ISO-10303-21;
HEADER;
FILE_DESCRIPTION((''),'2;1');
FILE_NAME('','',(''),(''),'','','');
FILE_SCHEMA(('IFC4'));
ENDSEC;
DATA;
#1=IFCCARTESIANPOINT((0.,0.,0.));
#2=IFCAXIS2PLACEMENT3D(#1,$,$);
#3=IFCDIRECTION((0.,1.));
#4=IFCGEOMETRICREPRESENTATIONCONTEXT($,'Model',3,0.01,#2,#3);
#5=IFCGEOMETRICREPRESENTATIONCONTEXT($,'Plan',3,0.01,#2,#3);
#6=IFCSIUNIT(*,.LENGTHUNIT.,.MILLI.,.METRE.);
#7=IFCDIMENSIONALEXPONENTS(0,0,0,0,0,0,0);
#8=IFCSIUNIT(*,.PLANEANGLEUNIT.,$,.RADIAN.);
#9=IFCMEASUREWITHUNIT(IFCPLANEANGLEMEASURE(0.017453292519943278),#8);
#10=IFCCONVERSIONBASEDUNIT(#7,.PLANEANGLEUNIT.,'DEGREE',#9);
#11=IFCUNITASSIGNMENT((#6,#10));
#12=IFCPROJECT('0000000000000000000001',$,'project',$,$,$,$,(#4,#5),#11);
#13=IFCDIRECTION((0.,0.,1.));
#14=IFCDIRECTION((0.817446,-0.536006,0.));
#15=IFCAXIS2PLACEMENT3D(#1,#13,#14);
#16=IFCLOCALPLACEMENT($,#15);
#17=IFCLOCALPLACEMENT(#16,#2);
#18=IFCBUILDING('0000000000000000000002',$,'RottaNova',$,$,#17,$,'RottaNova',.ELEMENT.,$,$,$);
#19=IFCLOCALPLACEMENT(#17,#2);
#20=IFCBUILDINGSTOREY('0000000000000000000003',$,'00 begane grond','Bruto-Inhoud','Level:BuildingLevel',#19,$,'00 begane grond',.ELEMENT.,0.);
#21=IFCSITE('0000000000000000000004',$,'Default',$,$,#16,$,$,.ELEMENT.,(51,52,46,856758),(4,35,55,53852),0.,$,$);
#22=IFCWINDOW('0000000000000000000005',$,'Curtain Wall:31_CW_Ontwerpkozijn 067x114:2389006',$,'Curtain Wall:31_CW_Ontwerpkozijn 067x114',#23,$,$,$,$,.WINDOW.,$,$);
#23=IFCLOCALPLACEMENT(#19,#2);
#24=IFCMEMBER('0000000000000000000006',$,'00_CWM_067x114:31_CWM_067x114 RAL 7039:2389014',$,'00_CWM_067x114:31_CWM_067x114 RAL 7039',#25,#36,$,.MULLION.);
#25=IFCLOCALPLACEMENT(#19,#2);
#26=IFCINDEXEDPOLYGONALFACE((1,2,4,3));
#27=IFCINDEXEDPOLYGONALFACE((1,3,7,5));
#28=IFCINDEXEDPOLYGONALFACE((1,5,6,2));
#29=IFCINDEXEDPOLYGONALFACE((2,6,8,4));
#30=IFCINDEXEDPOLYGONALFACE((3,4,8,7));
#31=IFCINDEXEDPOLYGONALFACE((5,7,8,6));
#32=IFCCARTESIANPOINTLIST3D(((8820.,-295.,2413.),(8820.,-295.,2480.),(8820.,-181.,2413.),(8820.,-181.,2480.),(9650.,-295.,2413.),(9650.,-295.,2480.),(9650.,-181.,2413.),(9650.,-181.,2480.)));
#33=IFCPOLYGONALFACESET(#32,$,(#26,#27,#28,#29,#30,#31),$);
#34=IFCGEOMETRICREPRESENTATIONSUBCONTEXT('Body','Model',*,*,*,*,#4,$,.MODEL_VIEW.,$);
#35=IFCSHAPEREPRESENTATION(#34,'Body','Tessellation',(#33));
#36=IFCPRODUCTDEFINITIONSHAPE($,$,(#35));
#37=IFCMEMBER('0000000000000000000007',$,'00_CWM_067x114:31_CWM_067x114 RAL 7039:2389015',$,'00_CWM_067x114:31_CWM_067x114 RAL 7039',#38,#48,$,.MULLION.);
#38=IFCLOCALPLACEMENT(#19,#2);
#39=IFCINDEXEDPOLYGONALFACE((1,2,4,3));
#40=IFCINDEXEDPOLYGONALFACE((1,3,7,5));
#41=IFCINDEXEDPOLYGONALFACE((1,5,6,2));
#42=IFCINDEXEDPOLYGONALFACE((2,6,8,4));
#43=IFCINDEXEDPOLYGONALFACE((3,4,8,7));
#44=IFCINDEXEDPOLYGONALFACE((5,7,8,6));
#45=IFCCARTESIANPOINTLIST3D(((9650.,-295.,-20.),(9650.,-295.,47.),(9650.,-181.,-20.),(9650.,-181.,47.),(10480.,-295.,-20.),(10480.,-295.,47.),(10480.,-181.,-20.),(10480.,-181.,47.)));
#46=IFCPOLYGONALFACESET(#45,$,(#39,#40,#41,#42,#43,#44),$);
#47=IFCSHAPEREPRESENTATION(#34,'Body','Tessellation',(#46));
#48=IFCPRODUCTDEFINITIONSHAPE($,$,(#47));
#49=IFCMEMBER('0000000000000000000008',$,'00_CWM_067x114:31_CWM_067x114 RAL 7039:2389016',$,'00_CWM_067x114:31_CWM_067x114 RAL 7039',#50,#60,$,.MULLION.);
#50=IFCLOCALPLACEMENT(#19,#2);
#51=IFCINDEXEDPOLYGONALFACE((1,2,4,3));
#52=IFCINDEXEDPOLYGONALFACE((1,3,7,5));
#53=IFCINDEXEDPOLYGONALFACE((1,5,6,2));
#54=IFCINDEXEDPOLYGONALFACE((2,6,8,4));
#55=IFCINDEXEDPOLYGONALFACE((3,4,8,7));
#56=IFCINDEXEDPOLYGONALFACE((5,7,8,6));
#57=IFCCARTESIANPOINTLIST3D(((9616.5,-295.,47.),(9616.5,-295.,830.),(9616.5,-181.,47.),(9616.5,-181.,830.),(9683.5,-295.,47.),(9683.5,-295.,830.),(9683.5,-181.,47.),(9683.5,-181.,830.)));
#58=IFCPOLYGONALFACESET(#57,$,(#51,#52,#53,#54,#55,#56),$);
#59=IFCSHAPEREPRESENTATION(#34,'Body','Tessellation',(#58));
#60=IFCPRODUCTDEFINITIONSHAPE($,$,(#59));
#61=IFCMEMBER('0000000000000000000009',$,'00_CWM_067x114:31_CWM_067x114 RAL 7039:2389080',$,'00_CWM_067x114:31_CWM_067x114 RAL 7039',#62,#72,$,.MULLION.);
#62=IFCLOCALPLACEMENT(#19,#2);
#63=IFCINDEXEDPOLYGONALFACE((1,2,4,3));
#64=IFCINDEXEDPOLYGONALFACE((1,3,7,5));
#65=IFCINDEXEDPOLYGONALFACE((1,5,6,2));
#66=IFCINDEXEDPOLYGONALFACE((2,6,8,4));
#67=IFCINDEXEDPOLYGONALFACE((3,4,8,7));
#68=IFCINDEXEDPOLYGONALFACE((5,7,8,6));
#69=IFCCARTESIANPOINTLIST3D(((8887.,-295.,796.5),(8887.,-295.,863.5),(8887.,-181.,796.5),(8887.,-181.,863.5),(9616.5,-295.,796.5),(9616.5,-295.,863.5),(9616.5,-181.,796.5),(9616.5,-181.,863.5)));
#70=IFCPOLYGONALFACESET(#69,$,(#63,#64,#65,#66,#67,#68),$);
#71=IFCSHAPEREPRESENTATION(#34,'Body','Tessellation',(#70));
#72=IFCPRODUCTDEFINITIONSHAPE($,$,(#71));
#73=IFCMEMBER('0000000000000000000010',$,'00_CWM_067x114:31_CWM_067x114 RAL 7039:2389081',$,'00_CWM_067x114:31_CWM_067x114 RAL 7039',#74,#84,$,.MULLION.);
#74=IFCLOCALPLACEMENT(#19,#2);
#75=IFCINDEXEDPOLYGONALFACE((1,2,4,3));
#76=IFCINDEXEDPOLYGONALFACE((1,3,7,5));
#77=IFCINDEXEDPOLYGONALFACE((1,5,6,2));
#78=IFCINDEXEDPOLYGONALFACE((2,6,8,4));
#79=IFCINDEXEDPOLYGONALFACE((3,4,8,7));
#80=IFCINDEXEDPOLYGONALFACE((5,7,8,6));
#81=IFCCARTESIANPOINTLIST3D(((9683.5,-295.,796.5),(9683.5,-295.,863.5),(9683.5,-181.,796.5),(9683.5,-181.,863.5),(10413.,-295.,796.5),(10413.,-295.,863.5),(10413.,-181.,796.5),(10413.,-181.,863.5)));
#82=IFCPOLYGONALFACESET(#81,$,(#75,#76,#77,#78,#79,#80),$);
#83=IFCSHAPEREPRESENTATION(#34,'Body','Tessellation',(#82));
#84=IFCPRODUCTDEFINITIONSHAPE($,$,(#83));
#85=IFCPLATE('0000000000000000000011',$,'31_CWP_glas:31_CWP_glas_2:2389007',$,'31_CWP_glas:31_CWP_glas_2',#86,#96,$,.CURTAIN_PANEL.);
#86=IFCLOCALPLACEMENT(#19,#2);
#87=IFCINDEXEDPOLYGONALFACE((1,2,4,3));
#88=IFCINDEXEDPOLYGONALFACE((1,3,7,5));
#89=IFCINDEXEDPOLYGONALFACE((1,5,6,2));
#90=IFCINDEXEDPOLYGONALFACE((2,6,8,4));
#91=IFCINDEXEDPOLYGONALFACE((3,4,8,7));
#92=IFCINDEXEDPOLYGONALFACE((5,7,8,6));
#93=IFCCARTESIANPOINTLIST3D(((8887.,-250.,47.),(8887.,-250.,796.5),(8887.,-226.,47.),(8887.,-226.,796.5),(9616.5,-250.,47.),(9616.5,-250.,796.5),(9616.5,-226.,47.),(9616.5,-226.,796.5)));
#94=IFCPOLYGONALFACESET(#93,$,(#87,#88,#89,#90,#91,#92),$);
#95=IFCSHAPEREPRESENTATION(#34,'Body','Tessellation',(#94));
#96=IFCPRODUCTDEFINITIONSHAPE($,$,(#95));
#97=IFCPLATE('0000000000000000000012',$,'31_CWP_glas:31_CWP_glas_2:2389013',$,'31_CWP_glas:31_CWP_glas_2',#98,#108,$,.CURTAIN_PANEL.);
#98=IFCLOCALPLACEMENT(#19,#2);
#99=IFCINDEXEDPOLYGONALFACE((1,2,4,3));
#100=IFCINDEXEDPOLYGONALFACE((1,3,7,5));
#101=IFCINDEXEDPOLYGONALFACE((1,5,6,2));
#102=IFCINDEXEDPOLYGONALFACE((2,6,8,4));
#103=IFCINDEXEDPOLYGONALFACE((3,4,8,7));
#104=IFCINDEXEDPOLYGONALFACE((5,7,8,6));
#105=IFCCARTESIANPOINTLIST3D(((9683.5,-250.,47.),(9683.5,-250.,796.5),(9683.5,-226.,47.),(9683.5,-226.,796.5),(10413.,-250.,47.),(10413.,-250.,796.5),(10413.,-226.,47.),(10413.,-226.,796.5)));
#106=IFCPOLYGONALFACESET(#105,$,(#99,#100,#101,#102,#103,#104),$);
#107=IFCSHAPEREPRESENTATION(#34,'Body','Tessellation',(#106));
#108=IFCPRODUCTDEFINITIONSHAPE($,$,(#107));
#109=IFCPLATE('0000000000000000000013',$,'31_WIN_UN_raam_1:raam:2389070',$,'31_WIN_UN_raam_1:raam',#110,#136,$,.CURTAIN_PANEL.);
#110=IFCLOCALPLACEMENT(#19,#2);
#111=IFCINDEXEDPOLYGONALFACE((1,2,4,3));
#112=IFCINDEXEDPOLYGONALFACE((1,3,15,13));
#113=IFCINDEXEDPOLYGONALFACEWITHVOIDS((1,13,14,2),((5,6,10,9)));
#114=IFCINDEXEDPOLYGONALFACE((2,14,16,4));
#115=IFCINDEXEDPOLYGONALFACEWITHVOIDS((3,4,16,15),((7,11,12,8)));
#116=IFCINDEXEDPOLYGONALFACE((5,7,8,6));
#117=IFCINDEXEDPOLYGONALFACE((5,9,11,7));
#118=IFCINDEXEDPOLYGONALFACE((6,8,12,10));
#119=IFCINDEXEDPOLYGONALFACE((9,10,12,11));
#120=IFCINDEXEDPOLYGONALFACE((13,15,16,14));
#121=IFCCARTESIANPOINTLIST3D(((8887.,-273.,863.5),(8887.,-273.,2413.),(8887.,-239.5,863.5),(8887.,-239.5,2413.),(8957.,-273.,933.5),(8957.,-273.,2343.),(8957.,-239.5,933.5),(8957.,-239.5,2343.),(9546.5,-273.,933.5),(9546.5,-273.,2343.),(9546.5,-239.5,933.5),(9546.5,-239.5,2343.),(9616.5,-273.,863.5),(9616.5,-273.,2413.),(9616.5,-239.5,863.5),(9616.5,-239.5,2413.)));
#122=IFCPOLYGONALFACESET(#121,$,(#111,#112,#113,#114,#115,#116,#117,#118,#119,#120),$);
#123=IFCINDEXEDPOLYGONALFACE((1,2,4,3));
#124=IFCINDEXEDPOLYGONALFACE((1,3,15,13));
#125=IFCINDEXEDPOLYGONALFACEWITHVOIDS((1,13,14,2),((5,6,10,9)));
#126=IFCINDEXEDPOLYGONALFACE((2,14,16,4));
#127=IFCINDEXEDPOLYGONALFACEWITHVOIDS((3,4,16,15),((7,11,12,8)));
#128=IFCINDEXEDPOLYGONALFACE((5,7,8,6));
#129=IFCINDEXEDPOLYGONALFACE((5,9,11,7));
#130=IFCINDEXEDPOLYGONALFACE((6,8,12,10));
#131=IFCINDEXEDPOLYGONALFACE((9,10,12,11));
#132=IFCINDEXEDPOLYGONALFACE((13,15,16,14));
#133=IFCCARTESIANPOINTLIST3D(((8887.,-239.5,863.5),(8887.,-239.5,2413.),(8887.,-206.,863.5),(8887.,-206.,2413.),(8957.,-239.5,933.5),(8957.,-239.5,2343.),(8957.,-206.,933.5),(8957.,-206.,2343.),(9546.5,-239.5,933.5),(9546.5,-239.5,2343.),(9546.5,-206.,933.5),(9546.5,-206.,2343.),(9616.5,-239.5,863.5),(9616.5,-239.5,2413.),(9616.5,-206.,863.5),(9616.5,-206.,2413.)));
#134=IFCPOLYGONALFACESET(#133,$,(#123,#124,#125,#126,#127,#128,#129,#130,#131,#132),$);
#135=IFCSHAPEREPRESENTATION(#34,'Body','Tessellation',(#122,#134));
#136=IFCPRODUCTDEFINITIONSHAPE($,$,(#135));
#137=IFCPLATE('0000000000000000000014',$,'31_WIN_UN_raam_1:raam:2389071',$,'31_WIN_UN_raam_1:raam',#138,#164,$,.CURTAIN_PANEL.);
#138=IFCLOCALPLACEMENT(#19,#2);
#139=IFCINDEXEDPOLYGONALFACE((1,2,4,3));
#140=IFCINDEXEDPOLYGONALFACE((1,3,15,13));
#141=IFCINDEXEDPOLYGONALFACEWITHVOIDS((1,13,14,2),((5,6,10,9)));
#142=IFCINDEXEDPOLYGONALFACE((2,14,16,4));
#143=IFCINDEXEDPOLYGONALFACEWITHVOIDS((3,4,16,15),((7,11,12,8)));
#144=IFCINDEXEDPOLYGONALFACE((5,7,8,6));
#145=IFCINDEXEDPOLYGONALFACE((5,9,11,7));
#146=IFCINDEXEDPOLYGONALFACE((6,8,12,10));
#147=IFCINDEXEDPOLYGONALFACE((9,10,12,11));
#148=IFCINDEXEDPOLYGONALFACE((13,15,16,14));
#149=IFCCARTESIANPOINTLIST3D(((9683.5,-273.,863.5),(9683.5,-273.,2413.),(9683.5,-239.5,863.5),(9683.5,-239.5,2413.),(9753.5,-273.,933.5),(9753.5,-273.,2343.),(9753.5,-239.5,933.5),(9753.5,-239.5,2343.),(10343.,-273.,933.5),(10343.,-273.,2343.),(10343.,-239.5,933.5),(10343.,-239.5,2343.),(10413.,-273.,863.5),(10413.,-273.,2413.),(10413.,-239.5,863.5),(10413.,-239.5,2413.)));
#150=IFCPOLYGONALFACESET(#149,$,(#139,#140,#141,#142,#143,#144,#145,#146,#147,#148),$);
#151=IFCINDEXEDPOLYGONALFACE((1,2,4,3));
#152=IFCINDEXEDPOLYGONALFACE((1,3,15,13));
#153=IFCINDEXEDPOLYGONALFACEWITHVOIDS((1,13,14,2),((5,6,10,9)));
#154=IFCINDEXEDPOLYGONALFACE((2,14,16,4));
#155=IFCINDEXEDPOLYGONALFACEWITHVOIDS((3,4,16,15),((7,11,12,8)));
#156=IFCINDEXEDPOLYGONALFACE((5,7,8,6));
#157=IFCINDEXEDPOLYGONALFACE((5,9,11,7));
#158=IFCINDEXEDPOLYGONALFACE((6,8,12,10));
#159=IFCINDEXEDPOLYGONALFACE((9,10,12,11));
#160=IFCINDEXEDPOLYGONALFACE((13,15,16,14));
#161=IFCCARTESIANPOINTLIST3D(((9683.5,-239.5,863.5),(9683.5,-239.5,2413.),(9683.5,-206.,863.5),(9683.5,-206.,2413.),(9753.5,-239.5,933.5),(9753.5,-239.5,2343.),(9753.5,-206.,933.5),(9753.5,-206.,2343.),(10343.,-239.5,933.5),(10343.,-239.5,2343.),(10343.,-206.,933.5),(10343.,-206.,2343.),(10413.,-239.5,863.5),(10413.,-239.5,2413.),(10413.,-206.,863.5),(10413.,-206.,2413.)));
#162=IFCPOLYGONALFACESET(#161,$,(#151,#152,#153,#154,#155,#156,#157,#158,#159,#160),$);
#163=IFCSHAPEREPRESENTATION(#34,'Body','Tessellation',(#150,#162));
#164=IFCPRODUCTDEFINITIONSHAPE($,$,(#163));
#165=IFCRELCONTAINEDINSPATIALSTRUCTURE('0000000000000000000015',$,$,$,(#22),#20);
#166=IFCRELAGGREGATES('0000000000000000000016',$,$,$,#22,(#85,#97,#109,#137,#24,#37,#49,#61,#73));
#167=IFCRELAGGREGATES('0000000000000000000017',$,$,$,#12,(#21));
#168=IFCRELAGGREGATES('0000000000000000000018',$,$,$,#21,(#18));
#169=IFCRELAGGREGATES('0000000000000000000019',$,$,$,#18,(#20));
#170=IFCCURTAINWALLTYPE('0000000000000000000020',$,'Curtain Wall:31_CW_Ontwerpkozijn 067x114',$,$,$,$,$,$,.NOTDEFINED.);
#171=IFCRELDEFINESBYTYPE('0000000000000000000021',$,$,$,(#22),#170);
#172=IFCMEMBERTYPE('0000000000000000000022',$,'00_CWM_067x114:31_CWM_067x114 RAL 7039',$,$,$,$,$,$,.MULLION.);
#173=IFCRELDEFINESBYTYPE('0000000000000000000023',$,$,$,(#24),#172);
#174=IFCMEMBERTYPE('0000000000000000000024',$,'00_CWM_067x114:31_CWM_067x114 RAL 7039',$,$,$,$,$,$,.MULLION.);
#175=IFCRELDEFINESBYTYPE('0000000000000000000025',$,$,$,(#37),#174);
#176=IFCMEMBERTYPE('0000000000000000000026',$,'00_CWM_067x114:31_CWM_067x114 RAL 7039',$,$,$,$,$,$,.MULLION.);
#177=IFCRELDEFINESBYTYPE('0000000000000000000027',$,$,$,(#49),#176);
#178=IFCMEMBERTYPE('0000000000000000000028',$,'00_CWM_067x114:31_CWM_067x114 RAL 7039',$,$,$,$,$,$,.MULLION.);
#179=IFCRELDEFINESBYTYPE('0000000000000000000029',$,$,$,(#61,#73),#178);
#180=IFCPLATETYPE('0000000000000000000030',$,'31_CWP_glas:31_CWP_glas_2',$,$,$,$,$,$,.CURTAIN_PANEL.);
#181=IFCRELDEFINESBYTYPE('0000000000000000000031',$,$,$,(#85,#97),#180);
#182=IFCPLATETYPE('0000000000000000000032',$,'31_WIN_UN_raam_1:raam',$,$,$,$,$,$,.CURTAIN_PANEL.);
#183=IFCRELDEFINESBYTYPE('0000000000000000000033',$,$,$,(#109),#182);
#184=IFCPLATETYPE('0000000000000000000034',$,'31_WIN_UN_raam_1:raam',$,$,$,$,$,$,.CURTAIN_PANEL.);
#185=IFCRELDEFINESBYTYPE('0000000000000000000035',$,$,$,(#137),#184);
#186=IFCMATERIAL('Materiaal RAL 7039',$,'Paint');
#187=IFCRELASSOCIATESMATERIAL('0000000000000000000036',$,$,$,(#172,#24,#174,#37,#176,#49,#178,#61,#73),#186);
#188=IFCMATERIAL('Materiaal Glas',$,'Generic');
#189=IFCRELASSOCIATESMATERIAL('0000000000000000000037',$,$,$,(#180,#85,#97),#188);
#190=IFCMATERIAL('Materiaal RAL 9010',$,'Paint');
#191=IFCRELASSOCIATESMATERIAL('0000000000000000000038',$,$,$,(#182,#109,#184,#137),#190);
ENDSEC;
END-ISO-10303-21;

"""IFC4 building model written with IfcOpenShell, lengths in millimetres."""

from ifc_helpers import new_model, entity, si_unit, converted_unit, direction, frame, origin, place, context, subcontext, project, spatial, indexed_curve, outline, extrude, source, transform, mapped, material, type_object, type_shapes, element, aggregate, save


model = new_model("IFC4")

# Units and contexts
model_context = context("Model", 3, precision=0.01, world=origin(), true_north=direction((0.0, 1.0)))
plan_context = context("Plan", 3, precision=0.01, world=origin(), true_north=direction((0.0, 1.0)))
body_context = subcontext(model_context, "Body", "Model", "MODEL_VIEW")
ifc_project = project(units=[si_unit("LENGTHUNIT", "METRE", prefix="MILLI"), converted_unit("PLANEANGLEUNIT", "DEGREE", entity("IfcPlaneAngleMeasure", 0.017453292519943278), si_unit("PLANEANGLEUNIT", "RADIAN"), dimensions=[0, 0, 0, 0, 0, 0, 0])], contexts=[model_context, plan_context])

# Site, building, storey
site_placement = place(None, frame((0.0, 0.0, 0.0), z_axis=(0.0, 0.0, 1.0), x_axis=(0.817446, -0.536006, 0.0)))
site = spatial("IfcSite", under=ifc_project, at=site_placement, Name="Default", CompositionType="ELEMENT", RefLatitude=(51, 52, 46, 856758), RefLongitude=(4, 35, 55, 53852), RefElevation=0.0)
building_placement = place(site_placement, origin())
building = spatial("IfcBuilding", under=site, at=building_placement, Name="RottaNova", LongName="RottaNova", CompositionType="ELEMENT")
storey_placement = place(building_placement, origin())
storey = spatial("IfcBuildingStorey", under=building, at=storey_placement, Name="00 begane grond", Description="Bruto-Inhoud", ObjectType="Level:BuildingLevel", LongName="00 begane grond", CompositionType="ELEMENT", Elevation=0.0)

# Shared definitions
curtain_wall_type = type_object("IfcCurtainWallType", Name="Curtain Wall:31_CW_Ontwerpkozijn 067x114", PredefinedType="NOTDEFINED")
ifc_material_1 = material(Name="Materiaal RAL 7039", Category="Paint")

# Window
window_1_placement = place(storey_placement, origin())
window_1 = element("IfcWindow", 1, at=window_1_placement, inside=storey, type_object=curtain_wall_type, Name="Curtain Wall:31_CW_Ontwerpkozijn 067x114:2389006", ObjectType="Curtain Wall:31_CW_Ontwerpkozijn 067x114", PredefinedType="WINDOW")

# Members
member_type_1 = type_object("IfcMemberType", Name="00_CWM_067x114:31_CWM_067x114 RAL 7039", PredefinedType="MULLION", material=ifc_material_1)
shared_shape_1 = source(origin(), body_context, "Body", "SweptSolid", [
    extrude(outline(indexed_curve([(-33.5, -57.0), (33.5, -57.0), (33.5, 57.0), (-33.5, 57.0), (-33.5, -57.0)], self_intersect=False)), frame((-33.5, 57.0, -830.0), z_axis=(0.0, 0.0, 1.0), x_axis=(-1.0, 0.0, 0.0)), (0.0, 0.0, 1.0), 830.0),
])
type_shapes(member_type_1, [shared_shape_1])
member_1_placement = place(window_1_placement, frame((9650.0, -181.0, 2480.0), z_axis=(1.0, 0.0, 0.0), x_axis=(0.0, 0.0, 1.0)))
member_1 = element("IfcMember", 2, at=member_1_placement, type_object=member_type_1, material=ifc_material_1, Name="00_CWM_067x114:31_CWM_067x114 RAL 7039:2389014", ObjectType="00_CWM_067x114:31_CWM_067x114 RAL 7039", PredefinedType="MULLION", context=body_context, shape_type="MappedRepresentation", body=[
    mapped(shared_shape_1, transform((0.0, 0.0, 0.0), scale=1.0)),
])
member_type_2 = type_object("IfcMemberType", Name="00_CWM_067x114:31_CWM_067x114 RAL 7039", PredefinedType="MULLION", material=ifc_material_1)
shared_shape_2 = source(origin(), body_context, "Body", "SweptSolid", [
    extrude(outline(indexed_curve([(-33.5, -57.0), (33.5, -57.0), (33.5, 57.0), (-33.5, 57.0), (-33.5, -57.0)], self_intersect=False)), frame((-33.5, 57.0, -830.0), z_axis=(0.0, 0.0, 1.0), x_axis=(-1.0, 0.0, 0.0)), (0.0, 0.0, 1.0), 830.0),
])
type_shapes(member_type_2, [shared_shape_2])
member_2_placement = place(window_1_placement, frame((9650.0, -181.0, -20.0), z_axis=(-1.0, 0.0, 0.0), x_axis=(0.0, 0.0, -1.0)))
member_2 = element("IfcMember", 3, at=member_2_placement, type_object=member_type_2, material=ifc_material_1, Name="00_CWM_067x114:31_CWM_067x114 RAL 7039:2389015", ObjectType="00_CWM_067x114:31_CWM_067x114 RAL 7039", PredefinedType="MULLION", context=body_context, shape_type="MappedRepresentation", body=[
    mapped(shared_shape_2, transform((0.0, 0.0, 0.0), scale=1.0)),
])
member_type_3 = type_object("IfcMemberType", Name="00_CWM_067x114:31_CWM_067x114 RAL 7039", PredefinedType="MULLION", material=ifc_material_1)
shared_shape_3 = source(origin(), body_context, "Body", "SweptSolid", [
    extrude(outline(indexed_curve([(-33.5, -57.0), (33.5, -57.0), (33.5, 57.0), (-33.5, 57.0), (-33.5, -57.0)], self_intersect=False)), frame((0.0, 57.0, -783.0), z_axis=(0.0, 0.0, 1.0), x_axis=(-1.0, 0.0, 0.0)), (0.0, 0.0, 1.0), 783.0),
])
type_shapes(member_type_3, [shared_shape_3])
member_3_placement = place(window_1_placement, frame((9650.0, -181.0, 47.0), z_axis=(0.0, 0.0, -1.0), x_axis=(1.0, 0.0, 0.0)))
member_3 = element("IfcMember", 4, at=member_3_placement, type_object=member_type_3, material=ifc_material_1, Name="00_CWM_067x114:31_CWM_067x114 RAL 7039:2389016", ObjectType="00_CWM_067x114:31_CWM_067x114 RAL 7039", PredefinedType="MULLION", context=body_context, shape_type="MappedRepresentation", body=[
    mapped(shared_shape_3, transform((0.0, 0.0, 0.0), scale=1.0)),
])
member_type_4 = type_object("IfcMemberType", Name="00_CWM_067x114:31_CWM_067x114 RAL 7039", PredefinedType="MULLION", material=ifc_material_1)
shared_shape_4 = source(origin(), body_context, "Body", "SweptSolid", [
    extrude(outline(indexed_curve([(-33.5, -57.0), (33.5, -57.0), (33.5, 57.0), (-33.5, 57.0), (-33.5, -57.0)], self_intersect=False)), frame((0.0, 57.0, -729.5), z_axis=(0.0, 0.0, 1.0), x_axis=(-1.0, 0.0, 0.0)), (0.0, 0.0, 1.0), 729.5),
])
type_shapes(member_type_4, [shared_shape_4])
member_4_placement = place(window_1_placement, frame((9616.5, -181.0, 830.0), z_axis=(1.0, 0.0, 0.0), x_axis=(0.0, 0.0, 1.0)))
member_4 = element("IfcMember", 5, at=member_4_placement, type_object=member_type_4, material=ifc_material_1, Name="00_CWM_067x114:31_CWM_067x114 RAL 7039:2389080", ObjectType="00_CWM_067x114:31_CWM_067x114 RAL 7039", PredefinedType="MULLION", context=body_context, shape_type="MappedRepresentation", body=[
    mapped(shared_shape_4, transform((0.0, 0.0, 0.0), scale=1.0)),
])
member_5_placement = place(window_1_placement, frame((10413.0, -181.0, 830.0), z_axis=(1.0, 0.0, 0.0), x_axis=(0.0, 0.0, 1.0)))
member_5 = element("IfcMember", 6, at=member_5_placement, type_object=member_type_4, material=ifc_material_1, Name="00_CWM_067x114:31_CWM_067x114 RAL 7039:2389081", ObjectType="00_CWM_067x114:31_CWM_067x114 RAL 7039", PredefinedType="MULLION", context=body_context, shape_type="MappedRepresentation", body=[
    mapped(shared_shape_4, transform((0.0, 0.0, 0.0), scale=1.0)),
])

# Plates
ifc_material_2 = material(Name="Materiaal Glas", Category="Generic")
plate_type_1 = type_object("IfcPlateType", Name="31_CWP_glas:31_CWP_glas_2", PredefinedType="CURTAIN_PANEL", material=ifc_material_2)
shared_shape_5 = source(origin(), body_context, "Body", "SweptSolid", [
    extrude(outline(indexed_curve([(-12.0, -364.7), (12.0, -364.7), (12.0, 364.7), (-12.0, 364.7), (-12.0, -364.7)], self_intersect=False)), frame((0.0, -57.0, 0.0), z_axis=(0.0, 0.0, 1.0), x_axis=(0.0, 1.0, 0.0)), (0.0, 0.0, 1.0), 749.5),
])
type_shapes(plate_type_1, [shared_shape_5])
plate_1_placement = place(window_1_placement, frame((9251.7, -181.0, 47.0)))
plate_1 = element("IfcPlate", 7, at=plate_1_placement, type_object=plate_type_1, material=ifc_material_2, Name="31_CWP_glas:31_CWP_glas_2:2389007", ObjectType="31_CWP_glas:31_CWP_glas_2", PredefinedType="CURTAIN_PANEL", context=body_context, shape_type="MappedRepresentation", body=[
    mapped(shared_shape_5, transform((0.0, 0.0, 0.0), scale=1.0)),
])
plate_2_placement = place(window_1_placement, frame((10048.2, -181.0, 47.0)))
plate_2 = element("IfcPlate", 8, at=plate_2_placement, type_object=plate_type_1, material=ifc_material_2, Name="31_CWP_glas:31_CWP_glas_2:2389013", ObjectType="31_CWP_glas:31_CWP_glas_2", PredefinedType="CURTAIN_PANEL", context=body_context, shape_type="MappedRepresentation", body=[
    mapped(shared_shape_5, transform((0.0, 0.0, 0.0), scale=1.0)),
])
ifc_material_3 = material(Name="Materiaal RAL 9010", Category="Paint")
plate_type_2 = type_object("IfcPlateType", Name="31_WIN_UN_raam_1:raam", PredefinedType="CURTAIN_PANEL", material=ifc_material_3)
shared_shape_6 = source(origin(), body_context, "Body", "SweptSolid", [
    extrude(outline(indexed_curve([(-364.7, -774.7), (364.7, -774.7), (364.7, 774.7), (-364.7, 774.7), (-364.7, -774.7)], self_intersect=False), holes=[indexed_curve([(-294.7, 704.7), (294.7, 704.7), (294.7, -704.8), (-294.7, -704.8), (-294.7, 704.7)], self_intersect=False)]), frame((0.0, -92.0, 774.8), z_axis=(0.0, 1.0, 0.0), x_axis=(1.0, 0.0, 0.0)), (0.0, 0.0, 1.0), 33.5),
    extrude(outline(indexed_curve([(-364.7, -774.7), (364.7, -774.7), (364.7, 774.7), (-364.7, 774.7), (-364.7, -774.7)], self_intersect=False), holes=[indexed_curve([(-294.7, 704.7), (294.7, 704.7), (294.7, -704.8), (-294.7, -704.8), (-294.7, 704.7)], self_intersect=False)]), frame((0.0, -58.5, 774.8), z_axis=(0.0, 1.0, 0.0), x_axis=(1.0, 0.0, 0.0)), (0.0, 0.0, 1.0), 33.5),
])
type_shapes(plate_type_2, [shared_shape_6])
plate_3_placement = place(window_1_placement, frame((9251.7, -181.0, 863.5)))
plate_3 = element("IfcPlate", 9, at=plate_3_placement, type_object=plate_type_2, material=ifc_material_3, Name="31_WIN_UN_raam_1:raam:2389070", ObjectType="31_WIN_UN_raam_1:raam", PredefinedType="CURTAIN_PANEL", context=body_context, shape_type="MappedRepresentation", body=[
    mapped(shared_shape_6, transform((0.0, 0.0, 0.0), scale=1.0)),
])
plate_type_3 = type_object("IfcPlateType", Name="31_WIN_UN_raam_1:raam", PredefinedType="CURTAIN_PANEL", material=ifc_material_3)
shared_shape_7 = source(origin(), body_context, "Body", "SweptSolid", [
    extrude(outline(indexed_curve([(-364.7, -774.7), (364.7, -774.7), (364.7, 774.7), (-364.7, 774.7), (-364.7, -774.7)], self_intersect=False), holes=[indexed_curve([(-294.7, 704.7), (294.7, 704.7), (294.7, -704.8), (-294.7, -704.8), (-294.7, 704.7)], self_intersect=False)]), frame((0.0, -92.0, 774.8), z_axis=(0.0, 1.0, 0.0), x_axis=(1.0, 0.0, 0.0)), (0.0, 0.0, 1.0), 33.5),
    extrude(outline(indexed_curve([(-364.7, -774.7), (364.7, -774.7), (364.7, 774.7), (-364.7, 774.7), (-364.7, -774.7)], self_intersect=False), holes=[indexed_curve([(-294.7, 704.7), (294.7, 704.7), (294.7, -704.8), (-294.7, -704.8), (-294.7, 704.7)], self_intersect=False)]), frame((0.0, -58.5, 774.8), z_axis=(0.0, 1.0, 0.0), x_axis=(1.0, 0.0, 0.0)), (0.0, 0.0, 1.0), 33.5),
])
type_shapes(plate_type_3, [shared_shape_7])
plate_4_placement = place(window_1_placement, frame((10048.2, -181.0, 863.5)))
plate_4 = element("IfcPlate", 10, at=plate_4_placement, type_object=plate_type_3, material=ifc_material_3, Name="31_WIN_UN_raam_1:raam:2389071", ObjectType="31_WIN_UN_raam_1:raam", PredefinedType="CURTAIN_PANEL", context=body_context, shape_type="MappedRepresentation", body=[
    mapped(shared_shape_7, transform((0.0, 0.0, 0.0), scale=1.0)),
])
aggregate(window_1, [plate_1, plate_2, plate_3, plate_4, member_1, member_2, member_3, member_4, member_5])

save(model, "model.ifc")
